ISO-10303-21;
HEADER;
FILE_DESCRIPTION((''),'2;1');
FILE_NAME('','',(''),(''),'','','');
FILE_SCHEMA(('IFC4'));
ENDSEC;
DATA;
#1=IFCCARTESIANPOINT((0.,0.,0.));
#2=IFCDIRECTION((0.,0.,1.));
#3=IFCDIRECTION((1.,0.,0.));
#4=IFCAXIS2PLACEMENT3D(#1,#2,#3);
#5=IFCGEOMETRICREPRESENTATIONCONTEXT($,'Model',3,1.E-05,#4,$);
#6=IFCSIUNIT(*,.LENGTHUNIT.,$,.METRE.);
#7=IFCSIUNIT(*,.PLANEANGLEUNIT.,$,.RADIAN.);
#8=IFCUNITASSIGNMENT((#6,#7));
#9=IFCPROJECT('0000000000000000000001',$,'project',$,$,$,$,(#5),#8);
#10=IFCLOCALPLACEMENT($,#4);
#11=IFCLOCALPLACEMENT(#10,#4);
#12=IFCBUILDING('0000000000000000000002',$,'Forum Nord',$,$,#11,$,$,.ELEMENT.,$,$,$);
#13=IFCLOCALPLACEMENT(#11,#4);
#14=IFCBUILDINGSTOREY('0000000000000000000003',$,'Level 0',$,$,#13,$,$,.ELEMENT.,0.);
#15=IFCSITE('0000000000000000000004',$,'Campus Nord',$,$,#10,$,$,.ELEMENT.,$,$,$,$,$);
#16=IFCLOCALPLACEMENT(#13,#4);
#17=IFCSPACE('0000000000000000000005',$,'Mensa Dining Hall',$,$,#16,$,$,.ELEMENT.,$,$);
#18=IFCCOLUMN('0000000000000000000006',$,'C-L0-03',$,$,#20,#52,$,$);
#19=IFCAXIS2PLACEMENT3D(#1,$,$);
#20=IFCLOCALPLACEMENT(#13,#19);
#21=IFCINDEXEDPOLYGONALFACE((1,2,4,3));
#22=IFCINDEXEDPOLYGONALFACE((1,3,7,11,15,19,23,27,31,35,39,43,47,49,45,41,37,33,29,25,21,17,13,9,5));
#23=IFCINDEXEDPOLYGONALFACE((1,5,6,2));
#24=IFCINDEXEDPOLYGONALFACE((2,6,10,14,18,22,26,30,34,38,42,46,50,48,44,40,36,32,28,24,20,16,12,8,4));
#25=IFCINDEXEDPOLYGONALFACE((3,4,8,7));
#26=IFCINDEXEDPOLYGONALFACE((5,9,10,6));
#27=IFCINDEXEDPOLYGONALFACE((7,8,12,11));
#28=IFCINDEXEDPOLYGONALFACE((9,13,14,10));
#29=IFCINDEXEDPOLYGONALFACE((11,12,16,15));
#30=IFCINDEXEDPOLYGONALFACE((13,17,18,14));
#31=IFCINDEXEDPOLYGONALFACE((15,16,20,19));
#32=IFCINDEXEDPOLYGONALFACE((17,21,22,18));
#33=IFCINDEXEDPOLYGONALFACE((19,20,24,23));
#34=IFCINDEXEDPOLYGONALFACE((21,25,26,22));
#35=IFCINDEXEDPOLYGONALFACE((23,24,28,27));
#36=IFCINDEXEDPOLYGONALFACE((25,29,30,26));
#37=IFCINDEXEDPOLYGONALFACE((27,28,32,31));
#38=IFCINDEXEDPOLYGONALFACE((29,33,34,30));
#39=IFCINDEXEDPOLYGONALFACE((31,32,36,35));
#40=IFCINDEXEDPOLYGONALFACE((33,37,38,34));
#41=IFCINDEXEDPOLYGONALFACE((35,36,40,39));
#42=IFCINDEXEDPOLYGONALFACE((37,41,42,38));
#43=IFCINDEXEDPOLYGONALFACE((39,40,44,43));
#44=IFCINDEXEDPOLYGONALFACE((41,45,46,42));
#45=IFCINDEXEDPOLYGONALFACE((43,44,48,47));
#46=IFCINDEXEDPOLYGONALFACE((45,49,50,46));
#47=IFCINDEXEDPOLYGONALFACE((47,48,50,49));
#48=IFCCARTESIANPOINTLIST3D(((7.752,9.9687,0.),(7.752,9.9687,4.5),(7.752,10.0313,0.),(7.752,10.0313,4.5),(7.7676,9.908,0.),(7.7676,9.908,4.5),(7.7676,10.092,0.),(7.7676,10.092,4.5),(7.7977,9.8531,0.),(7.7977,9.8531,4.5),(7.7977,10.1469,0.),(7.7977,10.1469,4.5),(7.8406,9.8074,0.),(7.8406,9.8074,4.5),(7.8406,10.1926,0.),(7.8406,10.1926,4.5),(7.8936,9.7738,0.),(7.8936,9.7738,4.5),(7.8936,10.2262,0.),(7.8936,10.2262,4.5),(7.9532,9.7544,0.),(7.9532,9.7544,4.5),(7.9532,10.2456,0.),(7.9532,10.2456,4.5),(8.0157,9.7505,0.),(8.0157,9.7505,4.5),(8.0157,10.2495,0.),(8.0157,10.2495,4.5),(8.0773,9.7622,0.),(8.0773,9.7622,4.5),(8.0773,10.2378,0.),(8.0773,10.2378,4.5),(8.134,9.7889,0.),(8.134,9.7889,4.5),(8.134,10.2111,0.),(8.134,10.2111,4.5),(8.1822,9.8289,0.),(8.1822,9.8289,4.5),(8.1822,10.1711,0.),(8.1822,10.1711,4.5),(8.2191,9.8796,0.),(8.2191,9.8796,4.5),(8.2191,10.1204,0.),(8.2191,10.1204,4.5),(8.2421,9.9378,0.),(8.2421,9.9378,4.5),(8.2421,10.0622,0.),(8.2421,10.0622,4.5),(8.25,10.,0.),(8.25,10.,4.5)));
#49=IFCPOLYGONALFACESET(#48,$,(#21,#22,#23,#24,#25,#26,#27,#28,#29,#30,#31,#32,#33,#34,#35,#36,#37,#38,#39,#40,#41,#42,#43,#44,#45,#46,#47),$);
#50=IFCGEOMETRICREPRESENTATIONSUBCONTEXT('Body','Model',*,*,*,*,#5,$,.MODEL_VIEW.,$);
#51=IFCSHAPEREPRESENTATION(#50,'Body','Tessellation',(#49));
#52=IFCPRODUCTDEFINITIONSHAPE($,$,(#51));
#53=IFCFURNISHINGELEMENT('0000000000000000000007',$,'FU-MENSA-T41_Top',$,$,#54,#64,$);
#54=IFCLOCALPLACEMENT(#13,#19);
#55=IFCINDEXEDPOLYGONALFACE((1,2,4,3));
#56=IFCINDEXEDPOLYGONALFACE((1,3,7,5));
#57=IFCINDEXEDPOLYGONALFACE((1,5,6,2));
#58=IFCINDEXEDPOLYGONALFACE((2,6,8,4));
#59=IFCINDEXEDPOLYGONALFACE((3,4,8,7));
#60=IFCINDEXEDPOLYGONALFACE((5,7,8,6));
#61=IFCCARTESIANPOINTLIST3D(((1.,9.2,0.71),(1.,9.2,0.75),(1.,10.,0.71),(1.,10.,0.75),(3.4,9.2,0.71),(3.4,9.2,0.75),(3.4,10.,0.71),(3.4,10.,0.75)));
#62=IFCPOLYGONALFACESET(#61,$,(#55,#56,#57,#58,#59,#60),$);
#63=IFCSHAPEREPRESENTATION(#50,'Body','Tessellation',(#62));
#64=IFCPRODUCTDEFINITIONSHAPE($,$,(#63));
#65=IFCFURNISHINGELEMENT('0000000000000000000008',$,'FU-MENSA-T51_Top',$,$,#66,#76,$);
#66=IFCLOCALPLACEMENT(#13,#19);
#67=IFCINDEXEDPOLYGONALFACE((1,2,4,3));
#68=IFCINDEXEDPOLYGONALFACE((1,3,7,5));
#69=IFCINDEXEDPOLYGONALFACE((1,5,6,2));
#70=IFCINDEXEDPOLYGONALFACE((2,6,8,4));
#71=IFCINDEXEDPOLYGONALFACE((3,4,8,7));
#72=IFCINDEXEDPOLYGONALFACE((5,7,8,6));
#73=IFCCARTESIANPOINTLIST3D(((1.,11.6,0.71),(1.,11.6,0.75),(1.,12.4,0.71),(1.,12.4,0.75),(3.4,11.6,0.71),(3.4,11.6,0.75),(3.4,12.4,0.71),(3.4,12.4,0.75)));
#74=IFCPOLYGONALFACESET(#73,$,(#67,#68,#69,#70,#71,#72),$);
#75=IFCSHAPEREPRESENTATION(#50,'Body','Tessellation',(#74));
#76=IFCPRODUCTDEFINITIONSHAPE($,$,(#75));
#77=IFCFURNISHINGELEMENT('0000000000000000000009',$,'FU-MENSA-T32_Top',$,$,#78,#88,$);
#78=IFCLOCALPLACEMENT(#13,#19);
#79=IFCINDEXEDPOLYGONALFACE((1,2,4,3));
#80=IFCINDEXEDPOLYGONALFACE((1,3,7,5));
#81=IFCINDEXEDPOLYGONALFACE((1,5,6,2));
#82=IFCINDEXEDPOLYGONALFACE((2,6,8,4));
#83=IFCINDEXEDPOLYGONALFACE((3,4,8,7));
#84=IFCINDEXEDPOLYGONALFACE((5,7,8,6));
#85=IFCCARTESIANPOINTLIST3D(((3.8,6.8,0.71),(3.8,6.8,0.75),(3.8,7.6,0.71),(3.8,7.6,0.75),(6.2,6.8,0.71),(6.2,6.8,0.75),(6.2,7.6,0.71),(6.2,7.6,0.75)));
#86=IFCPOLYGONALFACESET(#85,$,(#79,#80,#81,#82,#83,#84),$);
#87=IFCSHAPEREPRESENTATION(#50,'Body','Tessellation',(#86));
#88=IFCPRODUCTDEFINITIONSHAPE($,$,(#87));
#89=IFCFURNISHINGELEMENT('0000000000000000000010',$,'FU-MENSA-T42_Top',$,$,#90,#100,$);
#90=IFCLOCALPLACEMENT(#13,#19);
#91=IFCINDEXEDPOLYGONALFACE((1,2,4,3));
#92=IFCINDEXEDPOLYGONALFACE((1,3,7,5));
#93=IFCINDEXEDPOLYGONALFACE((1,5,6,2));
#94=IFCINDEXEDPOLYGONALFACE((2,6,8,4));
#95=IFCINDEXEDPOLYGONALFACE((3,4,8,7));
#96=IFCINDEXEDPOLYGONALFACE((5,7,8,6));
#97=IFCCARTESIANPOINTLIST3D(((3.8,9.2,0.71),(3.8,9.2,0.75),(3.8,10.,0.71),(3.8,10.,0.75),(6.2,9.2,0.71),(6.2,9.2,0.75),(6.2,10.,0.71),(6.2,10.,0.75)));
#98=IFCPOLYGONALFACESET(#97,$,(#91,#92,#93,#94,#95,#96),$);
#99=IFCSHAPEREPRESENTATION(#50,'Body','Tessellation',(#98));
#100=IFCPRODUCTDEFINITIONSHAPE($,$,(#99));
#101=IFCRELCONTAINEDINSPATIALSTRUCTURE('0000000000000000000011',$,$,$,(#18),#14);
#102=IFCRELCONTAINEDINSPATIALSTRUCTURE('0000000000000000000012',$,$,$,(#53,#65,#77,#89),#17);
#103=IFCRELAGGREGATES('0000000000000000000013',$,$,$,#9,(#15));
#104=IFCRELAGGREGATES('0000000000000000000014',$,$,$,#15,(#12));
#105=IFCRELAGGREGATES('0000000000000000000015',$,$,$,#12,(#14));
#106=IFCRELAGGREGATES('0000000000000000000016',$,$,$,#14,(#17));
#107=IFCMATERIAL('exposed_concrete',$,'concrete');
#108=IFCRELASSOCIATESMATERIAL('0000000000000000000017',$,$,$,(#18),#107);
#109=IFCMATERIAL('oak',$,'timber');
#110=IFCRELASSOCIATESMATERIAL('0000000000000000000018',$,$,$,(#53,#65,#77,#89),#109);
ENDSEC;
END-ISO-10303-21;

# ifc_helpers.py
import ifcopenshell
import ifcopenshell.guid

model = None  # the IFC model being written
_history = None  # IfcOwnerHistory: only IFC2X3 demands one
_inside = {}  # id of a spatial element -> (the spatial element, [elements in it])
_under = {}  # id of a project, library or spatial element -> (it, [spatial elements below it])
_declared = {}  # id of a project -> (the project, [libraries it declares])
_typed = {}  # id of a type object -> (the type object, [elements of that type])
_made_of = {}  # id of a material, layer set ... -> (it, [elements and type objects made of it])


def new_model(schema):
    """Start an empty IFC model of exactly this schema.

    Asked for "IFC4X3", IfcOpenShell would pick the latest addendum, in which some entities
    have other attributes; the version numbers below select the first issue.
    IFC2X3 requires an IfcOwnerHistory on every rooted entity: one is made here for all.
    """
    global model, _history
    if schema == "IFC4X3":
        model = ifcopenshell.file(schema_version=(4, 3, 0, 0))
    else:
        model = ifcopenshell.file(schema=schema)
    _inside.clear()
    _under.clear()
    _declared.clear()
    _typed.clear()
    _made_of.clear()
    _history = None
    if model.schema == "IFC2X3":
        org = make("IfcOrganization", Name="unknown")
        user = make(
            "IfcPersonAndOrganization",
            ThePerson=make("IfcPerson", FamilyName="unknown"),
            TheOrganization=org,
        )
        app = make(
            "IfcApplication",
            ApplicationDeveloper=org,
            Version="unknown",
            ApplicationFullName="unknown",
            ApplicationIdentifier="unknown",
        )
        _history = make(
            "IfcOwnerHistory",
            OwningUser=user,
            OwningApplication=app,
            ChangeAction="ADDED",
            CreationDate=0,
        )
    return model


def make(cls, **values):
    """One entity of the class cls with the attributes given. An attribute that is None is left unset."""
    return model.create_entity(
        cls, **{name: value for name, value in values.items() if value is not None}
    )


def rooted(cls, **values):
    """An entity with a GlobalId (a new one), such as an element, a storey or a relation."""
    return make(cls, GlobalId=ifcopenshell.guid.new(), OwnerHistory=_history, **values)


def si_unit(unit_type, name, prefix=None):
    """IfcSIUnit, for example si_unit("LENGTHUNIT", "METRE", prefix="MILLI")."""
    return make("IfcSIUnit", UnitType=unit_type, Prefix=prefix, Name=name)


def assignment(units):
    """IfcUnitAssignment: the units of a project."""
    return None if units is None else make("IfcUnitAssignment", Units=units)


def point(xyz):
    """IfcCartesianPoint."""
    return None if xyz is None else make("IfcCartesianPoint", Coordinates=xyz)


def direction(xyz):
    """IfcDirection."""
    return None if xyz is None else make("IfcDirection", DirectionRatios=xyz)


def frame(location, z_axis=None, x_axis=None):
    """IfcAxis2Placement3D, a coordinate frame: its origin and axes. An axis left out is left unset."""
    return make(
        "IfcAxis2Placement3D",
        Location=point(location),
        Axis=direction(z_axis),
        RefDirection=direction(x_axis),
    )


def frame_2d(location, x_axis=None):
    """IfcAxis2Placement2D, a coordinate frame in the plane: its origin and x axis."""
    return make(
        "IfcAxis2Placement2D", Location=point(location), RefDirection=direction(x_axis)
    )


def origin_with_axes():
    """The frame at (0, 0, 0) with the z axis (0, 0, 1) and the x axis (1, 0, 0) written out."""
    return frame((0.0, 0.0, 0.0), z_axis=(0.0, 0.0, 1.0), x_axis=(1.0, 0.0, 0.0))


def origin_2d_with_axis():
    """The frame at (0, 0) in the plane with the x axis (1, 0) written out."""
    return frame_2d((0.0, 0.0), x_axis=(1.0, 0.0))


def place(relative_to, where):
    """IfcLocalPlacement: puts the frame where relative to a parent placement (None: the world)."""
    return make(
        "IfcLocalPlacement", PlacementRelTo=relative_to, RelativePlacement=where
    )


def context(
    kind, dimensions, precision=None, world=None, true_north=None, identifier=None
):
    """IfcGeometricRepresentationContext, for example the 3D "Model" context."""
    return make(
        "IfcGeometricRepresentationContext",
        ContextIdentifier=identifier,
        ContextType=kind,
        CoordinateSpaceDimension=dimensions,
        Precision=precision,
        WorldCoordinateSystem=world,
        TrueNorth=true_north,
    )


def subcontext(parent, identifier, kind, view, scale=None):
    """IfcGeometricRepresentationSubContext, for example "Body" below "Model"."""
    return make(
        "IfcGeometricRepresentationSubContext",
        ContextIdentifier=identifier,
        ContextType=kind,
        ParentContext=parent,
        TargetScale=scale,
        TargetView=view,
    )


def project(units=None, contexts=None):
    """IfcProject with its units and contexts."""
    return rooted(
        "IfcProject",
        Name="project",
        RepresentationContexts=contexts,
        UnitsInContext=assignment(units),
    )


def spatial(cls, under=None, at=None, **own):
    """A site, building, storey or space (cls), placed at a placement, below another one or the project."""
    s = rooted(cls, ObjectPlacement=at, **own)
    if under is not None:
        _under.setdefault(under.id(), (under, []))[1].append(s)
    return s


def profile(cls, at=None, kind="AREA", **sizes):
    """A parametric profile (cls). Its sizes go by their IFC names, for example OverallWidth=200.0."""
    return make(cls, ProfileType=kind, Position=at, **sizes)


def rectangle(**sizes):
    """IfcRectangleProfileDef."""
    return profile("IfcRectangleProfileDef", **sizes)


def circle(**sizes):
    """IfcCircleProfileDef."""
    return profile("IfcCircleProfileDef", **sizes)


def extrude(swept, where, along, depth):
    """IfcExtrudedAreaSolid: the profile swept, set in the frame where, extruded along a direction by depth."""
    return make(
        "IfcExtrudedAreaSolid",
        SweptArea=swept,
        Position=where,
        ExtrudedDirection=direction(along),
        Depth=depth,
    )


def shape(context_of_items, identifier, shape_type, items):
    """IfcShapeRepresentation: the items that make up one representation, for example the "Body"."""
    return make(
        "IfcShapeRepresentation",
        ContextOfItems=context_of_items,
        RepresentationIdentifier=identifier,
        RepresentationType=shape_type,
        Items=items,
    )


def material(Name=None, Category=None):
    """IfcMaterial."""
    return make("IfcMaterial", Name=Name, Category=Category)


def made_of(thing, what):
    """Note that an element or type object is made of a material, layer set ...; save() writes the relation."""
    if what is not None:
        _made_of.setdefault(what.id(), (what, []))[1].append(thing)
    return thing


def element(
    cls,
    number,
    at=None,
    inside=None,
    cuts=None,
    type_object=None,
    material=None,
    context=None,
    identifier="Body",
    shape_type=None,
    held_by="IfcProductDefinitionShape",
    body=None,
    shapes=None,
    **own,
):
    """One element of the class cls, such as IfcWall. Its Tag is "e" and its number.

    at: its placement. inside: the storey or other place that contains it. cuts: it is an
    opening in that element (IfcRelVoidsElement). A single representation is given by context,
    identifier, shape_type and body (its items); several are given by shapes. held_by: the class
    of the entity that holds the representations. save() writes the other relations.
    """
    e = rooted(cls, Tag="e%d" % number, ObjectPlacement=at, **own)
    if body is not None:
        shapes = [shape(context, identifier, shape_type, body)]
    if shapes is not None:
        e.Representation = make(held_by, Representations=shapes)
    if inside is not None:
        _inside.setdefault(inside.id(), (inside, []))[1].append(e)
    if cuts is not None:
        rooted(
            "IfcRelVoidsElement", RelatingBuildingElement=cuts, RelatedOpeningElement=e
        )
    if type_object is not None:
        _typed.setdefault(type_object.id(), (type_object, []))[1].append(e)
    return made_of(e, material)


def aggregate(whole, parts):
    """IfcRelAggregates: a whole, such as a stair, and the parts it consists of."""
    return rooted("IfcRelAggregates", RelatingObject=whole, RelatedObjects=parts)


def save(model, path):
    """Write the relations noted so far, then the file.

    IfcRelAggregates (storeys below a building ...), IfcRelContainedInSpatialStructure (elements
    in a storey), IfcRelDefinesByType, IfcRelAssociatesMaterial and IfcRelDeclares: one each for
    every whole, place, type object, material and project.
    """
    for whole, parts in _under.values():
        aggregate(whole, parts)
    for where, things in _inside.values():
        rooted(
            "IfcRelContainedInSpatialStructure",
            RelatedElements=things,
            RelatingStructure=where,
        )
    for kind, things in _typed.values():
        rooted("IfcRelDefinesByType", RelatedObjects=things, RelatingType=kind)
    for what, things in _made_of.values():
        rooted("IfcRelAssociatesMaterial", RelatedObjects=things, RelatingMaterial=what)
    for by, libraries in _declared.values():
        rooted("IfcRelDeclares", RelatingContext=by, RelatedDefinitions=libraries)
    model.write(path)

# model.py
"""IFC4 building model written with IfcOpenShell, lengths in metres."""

from ifc_helpers import new_model, si_unit, frame, frame_2d, origin_with_axes, origin_2d_with_axis, place, context, subcontext, project, spatial, rectangle, circle, extrude, material, element, save


model = new_model("IFC4")

# Units and contexts
model_context = context("Model", 3, precision=1e-05, world=origin_with_axes())
body_context = subcontext(model_context, "Body", "Model", "MODEL_VIEW")
ifc_project = project(units=[si_unit("LENGTHUNIT", "METRE"), si_unit("PLANEANGLEUNIT", "RADIAN")], contexts=[model_context])

# Site, building, storey
site_placement = place(None, origin_with_axes())
site = spatial("IfcSite", under=ifc_project, at=site_placement, Name="Campus Nord", CompositionType="ELEMENT")
building_placement = place(site_placement, origin_with_axes())
building = spatial("IfcBuilding", under=site, at=building_placement, Name="Forum Nord", CompositionType="ELEMENT")
storey_placement = place(building_placement, origin_with_axes())
storey = spatial("IfcBuildingStorey", under=building, at=storey_placement, Name="Level 0", CompositionType="ELEMENT", Elevation=0.0)

# Column
ifc_material_1 = material(Name="exposed_concrete", Category="concrete")
column_placement = place(storey_placement, frame((8.0, 10.0, 0.0), z_axis=(0.0, 0.0, 1.0), x_axis=(1.0, 0.0, 0.0)))
element("IfcColumn", 1, at=column_placement, inside=storey, material=ifc_material_1, Name="C-L0-03", context=body_context, shape_type="SweptSolid", body=[
    extrude(circle(Radius=0.25, at=origin_2d_with_axis()), origin_with_axes(), (0.0, 0.0, 1.0), 4.5),
])

# Shared definitions
space_placement = place(storey_placement, origin_with_axes())
space = spatial("IfcSpace", under=storey, at=space_placement, Name="Mensa Dining Hall", CompositionType="ELEMENT")

# Furnishing elements
ifc_material_2 = material(Name="oak", Category="timber")
furnishing_1_placement = place(storey_placement, frame((1.0, 9.2, 0.0), z_axis=(0.0, 0.0, 1.0), x_axis=(1.0, 0.0, 0.0)))
element("IfcFurnishingElement", 2, at=furnishing_1_placement, inside=space, material=ifc_material_2, Name="FU-MENSA-T41_Top", context=body_context, shape_type="SweptSolid", body=[
    extrude(rectangle(XDim=2.4, YDim=0.8, at=frame_2d((1.2, 0.4), x_axis=(1.0, 0.0))), frame((0.0, 0.0, 0.71), z_axis=(0.0, 0.0, 1.0), x_axis=(1.0, 0.0, 0.0)), (0.0, 0.0, 1.0), 0.04),
])
for number, where, z_axis, x_axis, name in (
    (3, (1.0, 11.6, 0.0), (0.0, 0.0, 1.0), (1.0, 0.0, 0.0), "FU-MENSA-T51_Top"),
    (4, (3.8, 6.8, 0.0), (0.0, 0.0, 1.0), (1.0, 0.0, 0.0), "FU-MENSA-T32_Top"),
):
    element("IfcFurnishingElement", number, at=place(storey_placement, frame(where, z_axis=z_axis, x_axis=x_axis)), inside=space, material=ifc_material_2, Name=name, context=body_context, shape_type="SweptSolid", body=[
        extrude(rectangle(XDim=2.4, YDim=0.8, at=frame_2d((1.2, 0.4), x_axis=(1.0, 0.0))), frame((0.0, 0.0, 0.71), z_axis=(0.0, 0.0, 1.0), x_axis=(1.0, 0.0, 0.0)), (0.0, 0.0, 1.0), 0.04),
    ])
furnishing_2_placement = place(storey_placement, frame((3.8, 9.2, 0.0), z_axis=(0.0, 0.0, 1.0), x_axis=(1.0, 0.0, 0.0)))
element("IfcFurnishingElement", 5, at=furnishing_2_placement, inside=space, material=ifc_material_2, Name="FU-MENSA-T42_Top", context=body_context, shape_type="SweptSolid", body=[
    extrude(rectangle(XDim=2.4, YDim=0.8, at=frame_2d((1.2, 0.4), x_axis=(1.0, 0.0))), frame((0.0, 0.0, 0.71), z_axis=(0.0, 0.0, 1.0), x_axis=(1.0, 0.0, 0.0)), (0.0, 0.0, 1.0), 0.04),
])

save(model, "model.ifc")
